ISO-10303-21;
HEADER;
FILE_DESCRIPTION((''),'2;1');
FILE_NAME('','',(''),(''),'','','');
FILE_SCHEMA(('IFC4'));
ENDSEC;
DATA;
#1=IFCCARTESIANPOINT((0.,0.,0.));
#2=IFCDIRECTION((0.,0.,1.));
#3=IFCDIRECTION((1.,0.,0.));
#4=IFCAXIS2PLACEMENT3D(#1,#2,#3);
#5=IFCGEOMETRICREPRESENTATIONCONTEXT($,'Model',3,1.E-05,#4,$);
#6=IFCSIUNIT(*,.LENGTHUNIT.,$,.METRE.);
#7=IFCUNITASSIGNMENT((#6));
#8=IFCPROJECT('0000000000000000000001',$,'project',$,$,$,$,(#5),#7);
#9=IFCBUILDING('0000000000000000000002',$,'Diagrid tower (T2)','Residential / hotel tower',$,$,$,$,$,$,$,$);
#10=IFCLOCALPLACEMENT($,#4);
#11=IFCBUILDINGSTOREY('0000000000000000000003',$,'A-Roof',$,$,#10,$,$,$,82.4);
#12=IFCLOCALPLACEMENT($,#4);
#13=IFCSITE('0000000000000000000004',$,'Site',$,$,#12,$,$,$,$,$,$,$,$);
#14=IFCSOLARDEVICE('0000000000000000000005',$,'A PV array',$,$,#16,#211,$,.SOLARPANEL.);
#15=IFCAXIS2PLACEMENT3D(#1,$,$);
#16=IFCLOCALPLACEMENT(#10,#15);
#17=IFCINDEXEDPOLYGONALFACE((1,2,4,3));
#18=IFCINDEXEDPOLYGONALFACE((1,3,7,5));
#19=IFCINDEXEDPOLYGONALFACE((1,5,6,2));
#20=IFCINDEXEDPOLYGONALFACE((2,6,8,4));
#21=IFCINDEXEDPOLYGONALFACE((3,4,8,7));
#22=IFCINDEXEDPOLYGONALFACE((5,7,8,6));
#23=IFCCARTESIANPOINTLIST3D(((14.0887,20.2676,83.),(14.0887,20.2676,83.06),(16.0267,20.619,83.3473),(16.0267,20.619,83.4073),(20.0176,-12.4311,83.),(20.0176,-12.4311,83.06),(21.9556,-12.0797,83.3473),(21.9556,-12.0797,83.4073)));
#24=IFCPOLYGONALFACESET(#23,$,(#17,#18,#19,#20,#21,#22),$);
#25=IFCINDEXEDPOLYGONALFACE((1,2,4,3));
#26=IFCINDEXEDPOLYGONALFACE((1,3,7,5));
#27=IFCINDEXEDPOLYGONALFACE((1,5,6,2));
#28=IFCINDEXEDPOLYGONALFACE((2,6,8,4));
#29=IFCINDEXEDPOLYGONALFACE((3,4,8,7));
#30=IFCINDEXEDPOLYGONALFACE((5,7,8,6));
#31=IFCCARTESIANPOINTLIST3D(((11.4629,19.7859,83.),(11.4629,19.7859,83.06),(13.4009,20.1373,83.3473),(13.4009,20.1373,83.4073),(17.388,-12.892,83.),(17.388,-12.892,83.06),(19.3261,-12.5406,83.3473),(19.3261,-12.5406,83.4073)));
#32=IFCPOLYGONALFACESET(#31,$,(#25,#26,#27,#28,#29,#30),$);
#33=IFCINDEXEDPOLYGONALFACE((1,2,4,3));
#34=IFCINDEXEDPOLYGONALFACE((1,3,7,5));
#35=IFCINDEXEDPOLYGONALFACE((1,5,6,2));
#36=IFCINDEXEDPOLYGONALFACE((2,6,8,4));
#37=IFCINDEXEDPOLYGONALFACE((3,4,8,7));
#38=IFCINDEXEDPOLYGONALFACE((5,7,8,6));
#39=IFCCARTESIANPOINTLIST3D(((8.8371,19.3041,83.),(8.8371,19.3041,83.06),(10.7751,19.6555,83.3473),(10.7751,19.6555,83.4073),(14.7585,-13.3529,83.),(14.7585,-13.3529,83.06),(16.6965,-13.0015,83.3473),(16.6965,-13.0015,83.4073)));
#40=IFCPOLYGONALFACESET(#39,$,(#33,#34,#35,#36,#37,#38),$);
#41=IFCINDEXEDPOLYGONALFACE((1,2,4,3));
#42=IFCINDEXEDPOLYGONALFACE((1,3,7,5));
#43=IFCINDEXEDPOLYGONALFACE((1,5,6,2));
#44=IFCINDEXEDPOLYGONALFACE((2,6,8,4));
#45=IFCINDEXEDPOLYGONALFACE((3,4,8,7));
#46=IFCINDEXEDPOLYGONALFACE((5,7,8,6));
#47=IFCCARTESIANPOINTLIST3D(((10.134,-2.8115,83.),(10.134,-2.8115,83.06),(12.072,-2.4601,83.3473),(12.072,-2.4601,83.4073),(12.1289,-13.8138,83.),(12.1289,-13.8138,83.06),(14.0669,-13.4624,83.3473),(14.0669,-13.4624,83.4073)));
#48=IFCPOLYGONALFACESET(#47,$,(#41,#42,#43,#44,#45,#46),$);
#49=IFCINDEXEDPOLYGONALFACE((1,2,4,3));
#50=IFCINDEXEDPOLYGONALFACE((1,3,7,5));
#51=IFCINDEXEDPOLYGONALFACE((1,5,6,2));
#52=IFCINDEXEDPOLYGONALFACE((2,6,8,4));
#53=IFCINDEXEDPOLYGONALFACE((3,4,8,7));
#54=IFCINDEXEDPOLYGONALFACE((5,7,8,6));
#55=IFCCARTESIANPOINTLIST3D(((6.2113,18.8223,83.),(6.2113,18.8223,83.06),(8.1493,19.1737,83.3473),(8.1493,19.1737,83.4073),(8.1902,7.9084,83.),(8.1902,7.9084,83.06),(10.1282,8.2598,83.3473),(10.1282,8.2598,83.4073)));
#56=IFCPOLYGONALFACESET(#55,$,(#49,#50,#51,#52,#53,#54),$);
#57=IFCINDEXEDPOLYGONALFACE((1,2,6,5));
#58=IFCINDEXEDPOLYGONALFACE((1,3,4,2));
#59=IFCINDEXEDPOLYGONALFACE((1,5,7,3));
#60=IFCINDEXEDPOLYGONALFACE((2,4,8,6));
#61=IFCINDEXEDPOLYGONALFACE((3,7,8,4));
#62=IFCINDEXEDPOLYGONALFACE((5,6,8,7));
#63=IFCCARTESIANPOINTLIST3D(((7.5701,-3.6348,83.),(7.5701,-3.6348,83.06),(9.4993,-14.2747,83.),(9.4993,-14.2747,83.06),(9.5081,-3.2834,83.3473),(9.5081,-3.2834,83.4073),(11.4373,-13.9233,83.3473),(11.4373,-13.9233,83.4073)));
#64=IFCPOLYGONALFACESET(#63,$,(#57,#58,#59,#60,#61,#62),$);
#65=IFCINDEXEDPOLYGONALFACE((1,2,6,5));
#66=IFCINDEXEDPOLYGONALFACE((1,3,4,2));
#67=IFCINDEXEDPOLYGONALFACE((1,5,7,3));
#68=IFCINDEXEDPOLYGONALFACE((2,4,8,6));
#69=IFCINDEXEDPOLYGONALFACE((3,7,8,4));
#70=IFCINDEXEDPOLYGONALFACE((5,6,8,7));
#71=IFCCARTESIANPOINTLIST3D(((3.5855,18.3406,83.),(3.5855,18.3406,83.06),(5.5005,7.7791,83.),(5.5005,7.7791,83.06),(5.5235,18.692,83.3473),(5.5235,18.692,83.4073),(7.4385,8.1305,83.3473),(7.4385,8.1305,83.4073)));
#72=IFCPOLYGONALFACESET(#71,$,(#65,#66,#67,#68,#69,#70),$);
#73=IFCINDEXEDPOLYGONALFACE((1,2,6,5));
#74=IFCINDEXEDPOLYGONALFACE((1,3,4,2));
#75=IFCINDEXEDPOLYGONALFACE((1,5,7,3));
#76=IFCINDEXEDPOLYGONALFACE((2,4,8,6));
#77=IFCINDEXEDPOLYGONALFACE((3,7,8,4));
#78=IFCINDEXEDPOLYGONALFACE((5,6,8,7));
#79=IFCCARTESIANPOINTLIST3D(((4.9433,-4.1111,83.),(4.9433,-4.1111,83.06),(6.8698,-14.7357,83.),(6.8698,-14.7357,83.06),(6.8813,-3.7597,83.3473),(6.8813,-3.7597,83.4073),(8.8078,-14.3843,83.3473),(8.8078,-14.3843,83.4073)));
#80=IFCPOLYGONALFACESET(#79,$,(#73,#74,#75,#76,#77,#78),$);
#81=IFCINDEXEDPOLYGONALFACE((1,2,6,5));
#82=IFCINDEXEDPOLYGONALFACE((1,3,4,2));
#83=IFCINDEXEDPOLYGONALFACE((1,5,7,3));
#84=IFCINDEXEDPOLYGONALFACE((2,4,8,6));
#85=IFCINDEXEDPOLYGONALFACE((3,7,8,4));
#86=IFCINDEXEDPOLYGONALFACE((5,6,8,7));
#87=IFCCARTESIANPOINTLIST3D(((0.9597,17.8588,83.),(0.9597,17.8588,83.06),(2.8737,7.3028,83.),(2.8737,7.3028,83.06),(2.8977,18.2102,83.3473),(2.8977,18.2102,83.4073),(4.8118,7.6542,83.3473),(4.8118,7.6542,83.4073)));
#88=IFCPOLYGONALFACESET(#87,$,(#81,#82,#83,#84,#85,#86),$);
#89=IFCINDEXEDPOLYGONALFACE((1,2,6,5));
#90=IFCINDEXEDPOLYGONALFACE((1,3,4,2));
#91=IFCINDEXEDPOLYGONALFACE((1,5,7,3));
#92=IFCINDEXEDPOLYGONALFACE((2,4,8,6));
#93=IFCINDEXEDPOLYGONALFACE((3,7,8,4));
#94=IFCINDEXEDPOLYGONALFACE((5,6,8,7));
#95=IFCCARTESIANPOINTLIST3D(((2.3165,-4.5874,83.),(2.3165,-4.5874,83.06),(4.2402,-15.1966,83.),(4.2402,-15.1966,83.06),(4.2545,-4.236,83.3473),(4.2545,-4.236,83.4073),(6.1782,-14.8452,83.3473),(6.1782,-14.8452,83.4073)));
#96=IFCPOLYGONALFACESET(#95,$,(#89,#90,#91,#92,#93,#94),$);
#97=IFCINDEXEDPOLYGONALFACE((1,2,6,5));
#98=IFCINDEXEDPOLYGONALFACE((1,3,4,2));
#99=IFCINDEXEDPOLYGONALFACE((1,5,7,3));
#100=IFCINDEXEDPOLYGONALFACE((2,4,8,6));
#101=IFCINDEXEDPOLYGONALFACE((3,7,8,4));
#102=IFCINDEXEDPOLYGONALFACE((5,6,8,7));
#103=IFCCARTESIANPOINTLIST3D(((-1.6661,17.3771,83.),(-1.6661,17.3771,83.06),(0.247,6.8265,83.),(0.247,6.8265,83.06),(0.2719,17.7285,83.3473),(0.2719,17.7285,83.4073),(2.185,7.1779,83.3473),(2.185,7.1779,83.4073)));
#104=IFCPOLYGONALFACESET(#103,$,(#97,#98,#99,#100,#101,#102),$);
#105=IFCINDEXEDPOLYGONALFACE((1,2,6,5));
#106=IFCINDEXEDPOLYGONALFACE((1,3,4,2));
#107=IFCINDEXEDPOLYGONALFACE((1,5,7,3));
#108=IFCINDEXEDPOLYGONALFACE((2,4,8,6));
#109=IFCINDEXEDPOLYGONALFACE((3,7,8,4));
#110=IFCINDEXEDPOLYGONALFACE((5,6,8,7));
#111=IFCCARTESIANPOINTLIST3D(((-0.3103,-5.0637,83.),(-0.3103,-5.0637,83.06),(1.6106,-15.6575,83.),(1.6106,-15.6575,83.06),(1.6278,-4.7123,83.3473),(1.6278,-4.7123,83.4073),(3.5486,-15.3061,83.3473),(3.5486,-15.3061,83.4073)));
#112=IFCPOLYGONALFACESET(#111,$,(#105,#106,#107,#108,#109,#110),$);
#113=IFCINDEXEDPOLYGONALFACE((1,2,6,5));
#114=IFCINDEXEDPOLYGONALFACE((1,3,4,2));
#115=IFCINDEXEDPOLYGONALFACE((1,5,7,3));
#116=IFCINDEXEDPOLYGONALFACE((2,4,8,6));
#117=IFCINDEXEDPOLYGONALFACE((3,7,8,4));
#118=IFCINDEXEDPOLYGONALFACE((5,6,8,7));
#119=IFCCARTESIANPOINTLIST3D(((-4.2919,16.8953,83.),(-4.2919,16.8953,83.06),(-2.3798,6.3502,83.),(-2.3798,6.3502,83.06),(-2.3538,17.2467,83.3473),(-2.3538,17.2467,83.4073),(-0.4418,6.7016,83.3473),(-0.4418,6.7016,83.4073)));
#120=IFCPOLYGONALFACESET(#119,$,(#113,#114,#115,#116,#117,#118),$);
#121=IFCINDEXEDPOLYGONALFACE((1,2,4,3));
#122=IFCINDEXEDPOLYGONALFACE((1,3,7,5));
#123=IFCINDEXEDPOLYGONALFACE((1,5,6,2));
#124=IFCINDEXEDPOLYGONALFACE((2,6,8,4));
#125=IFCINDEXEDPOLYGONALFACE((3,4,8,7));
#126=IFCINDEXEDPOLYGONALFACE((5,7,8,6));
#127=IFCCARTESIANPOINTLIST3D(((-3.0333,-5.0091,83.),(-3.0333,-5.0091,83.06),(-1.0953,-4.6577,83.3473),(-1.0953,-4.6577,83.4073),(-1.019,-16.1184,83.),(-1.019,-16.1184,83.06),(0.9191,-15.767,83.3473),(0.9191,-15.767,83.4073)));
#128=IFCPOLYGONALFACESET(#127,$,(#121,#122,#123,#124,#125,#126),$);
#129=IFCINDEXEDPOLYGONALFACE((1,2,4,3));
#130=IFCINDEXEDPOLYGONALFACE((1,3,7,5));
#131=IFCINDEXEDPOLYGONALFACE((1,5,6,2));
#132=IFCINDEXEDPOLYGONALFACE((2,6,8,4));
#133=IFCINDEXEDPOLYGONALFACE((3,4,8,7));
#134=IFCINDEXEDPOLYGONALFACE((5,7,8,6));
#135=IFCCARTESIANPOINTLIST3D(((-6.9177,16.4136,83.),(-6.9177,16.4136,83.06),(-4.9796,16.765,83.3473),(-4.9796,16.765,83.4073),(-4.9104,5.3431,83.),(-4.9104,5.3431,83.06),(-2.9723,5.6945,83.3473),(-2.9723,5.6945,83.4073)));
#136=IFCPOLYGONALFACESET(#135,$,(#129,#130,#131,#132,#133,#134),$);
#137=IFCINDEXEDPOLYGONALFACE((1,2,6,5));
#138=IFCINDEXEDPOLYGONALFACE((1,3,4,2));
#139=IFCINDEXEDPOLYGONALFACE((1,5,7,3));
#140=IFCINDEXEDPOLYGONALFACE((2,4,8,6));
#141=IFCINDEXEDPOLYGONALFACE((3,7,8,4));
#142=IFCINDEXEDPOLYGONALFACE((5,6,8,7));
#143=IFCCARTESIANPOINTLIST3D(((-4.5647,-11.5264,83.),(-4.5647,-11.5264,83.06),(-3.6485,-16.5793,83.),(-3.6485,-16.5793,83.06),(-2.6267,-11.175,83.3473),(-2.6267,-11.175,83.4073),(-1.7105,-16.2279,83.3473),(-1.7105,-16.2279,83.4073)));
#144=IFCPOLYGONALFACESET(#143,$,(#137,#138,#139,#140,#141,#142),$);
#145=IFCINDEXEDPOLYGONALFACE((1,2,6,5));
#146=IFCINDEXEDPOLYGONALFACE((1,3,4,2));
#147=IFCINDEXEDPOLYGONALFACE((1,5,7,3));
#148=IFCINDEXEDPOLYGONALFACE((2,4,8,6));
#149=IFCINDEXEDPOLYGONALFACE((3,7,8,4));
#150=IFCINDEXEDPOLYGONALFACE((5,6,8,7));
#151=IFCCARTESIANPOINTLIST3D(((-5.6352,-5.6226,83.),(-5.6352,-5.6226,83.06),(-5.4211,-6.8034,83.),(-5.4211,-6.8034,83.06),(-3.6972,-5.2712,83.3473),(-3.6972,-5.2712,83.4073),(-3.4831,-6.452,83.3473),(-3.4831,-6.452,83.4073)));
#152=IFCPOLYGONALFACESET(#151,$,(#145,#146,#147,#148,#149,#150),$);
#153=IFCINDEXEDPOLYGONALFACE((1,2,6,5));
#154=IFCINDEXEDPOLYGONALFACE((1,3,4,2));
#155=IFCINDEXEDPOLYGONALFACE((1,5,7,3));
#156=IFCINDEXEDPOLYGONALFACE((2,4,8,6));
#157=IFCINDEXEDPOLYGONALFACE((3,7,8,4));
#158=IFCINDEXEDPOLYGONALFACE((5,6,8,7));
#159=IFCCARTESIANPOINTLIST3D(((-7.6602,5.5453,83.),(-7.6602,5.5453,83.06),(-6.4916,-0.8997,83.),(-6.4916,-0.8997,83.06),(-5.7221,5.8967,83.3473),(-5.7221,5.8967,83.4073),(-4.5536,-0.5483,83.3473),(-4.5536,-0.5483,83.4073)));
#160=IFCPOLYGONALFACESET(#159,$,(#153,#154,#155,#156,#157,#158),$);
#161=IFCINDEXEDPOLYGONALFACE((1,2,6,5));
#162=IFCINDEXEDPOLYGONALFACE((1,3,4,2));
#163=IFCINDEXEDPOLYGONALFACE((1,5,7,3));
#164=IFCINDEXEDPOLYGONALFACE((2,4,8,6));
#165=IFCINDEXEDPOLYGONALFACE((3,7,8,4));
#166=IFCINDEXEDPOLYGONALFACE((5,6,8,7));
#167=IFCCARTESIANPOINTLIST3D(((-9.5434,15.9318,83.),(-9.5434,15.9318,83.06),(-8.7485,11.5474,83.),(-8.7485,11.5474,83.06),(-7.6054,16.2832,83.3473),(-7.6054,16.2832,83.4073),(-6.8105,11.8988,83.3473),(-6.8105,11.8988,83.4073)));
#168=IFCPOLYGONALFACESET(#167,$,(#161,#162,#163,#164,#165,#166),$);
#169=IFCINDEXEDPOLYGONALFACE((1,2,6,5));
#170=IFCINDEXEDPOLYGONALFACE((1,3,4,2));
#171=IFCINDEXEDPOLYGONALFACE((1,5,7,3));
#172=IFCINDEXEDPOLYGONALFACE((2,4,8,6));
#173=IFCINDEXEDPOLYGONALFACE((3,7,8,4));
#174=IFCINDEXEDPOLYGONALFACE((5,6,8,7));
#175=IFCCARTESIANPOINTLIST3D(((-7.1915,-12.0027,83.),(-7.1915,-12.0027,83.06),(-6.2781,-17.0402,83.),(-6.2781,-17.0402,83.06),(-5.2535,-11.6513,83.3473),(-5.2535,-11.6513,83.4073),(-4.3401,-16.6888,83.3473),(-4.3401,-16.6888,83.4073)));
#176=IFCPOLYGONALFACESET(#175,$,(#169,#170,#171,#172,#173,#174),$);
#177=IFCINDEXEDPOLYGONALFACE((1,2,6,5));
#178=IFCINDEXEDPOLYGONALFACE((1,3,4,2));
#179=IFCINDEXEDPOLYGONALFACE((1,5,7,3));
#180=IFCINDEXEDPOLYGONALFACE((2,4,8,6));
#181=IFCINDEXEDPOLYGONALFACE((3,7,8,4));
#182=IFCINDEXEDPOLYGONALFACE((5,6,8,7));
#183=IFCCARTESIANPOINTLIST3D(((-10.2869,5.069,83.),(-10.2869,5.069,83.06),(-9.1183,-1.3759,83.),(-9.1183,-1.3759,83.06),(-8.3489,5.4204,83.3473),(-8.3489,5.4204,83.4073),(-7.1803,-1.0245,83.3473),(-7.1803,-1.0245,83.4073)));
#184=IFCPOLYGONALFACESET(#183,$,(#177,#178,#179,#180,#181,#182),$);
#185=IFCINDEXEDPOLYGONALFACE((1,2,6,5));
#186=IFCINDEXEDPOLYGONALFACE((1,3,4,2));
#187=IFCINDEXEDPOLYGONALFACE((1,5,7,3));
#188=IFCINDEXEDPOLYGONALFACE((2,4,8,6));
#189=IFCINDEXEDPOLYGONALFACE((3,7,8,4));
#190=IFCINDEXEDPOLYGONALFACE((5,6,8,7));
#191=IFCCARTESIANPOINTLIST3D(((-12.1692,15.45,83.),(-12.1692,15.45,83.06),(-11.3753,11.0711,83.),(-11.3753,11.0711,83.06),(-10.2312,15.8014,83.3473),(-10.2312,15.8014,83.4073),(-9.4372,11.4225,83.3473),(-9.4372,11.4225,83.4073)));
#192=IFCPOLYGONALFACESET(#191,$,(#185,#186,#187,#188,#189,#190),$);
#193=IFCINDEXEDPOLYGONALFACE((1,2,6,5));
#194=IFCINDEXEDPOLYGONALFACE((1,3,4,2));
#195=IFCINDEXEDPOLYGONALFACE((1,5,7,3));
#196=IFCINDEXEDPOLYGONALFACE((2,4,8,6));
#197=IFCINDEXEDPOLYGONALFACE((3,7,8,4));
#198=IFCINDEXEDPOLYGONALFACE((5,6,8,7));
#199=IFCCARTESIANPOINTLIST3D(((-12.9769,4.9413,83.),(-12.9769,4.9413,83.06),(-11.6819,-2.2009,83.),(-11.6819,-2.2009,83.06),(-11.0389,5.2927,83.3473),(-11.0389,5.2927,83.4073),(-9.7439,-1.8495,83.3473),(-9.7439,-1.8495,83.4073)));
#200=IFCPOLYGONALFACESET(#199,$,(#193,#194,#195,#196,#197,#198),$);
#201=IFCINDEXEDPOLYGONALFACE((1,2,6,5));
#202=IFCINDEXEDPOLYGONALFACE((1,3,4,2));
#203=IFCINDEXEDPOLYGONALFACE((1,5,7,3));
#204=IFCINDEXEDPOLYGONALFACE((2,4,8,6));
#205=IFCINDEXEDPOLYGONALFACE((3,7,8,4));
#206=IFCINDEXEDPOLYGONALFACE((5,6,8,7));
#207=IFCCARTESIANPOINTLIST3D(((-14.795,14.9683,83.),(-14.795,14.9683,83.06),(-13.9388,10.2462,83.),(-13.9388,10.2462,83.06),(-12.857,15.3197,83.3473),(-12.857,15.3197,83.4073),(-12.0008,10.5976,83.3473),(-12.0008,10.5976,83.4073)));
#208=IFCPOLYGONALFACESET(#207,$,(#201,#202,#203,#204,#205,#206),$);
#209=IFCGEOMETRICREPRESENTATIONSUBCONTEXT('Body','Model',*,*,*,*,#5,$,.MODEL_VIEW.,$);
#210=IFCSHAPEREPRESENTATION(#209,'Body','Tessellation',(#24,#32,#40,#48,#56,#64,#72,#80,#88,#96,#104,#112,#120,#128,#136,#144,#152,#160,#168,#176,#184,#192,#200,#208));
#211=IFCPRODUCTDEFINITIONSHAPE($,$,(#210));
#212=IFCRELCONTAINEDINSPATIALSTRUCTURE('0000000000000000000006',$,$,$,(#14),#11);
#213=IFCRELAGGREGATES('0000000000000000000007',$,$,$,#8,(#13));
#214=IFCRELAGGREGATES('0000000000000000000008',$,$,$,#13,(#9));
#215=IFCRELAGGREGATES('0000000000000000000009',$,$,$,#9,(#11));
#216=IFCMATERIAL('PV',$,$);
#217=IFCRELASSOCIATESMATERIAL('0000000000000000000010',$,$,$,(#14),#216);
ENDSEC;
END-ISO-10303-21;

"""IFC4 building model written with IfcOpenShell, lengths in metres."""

from ifc_helpers import new_model, si_unit, frame, origin_with_axes, place, context, subcontext, project, spatial, polyline, outline, extrude, material, element, save


model = new_model("IFC4")

# Units and contexts
model_context = context("Model", 3, precision=1e-05, world=origin_with_axes())
body_context = subcontext(model_context, "Body", "Model", "MODEL_VIEW")
ifc_project = project(units=[si_unit("LENGTHUNIT", "METRE")], contexts=[model_context])

# Site, building, storey
site_placement = place(None, origin_with_axes())
site = spatial("IfcSite", under=ifc_project, at=site_placement, Name="Site")
building = spatial("IfcBuilding", under=site, Name="Diagrid tower (T2)", Description="Residential / hotel tower")
storey_placement = place(None, origin_with_axes())
storey = spatial("IfcBuildingStorey", under=building, at=storey_placement, Name="A-Roof", Elevation=82.4)

# Solar device
ifc_material_1 = material(Name="PV")
solar_device_placement = place(storey_placement, origin_with_axes())
element("IfcSolarDevice", 1, at=solar_device_placement, inside=storey, material=ifc_material_1, Name="A PV array", PredefinedType="SOLARPANEL", context=body_context, shape_type="SweptSolid", body=[
    extrude(outline(polyline([(0.0, 0.6473), (1.9696, 0.3), (1.9696, 0.36), (0.0, 0.7073), (0.0, 0.6473)])), frame((21.9556, -12.0797, 82.7), z_axis=(-0.178411, 0.983956, 0.0), x_axis=(-0.983956, -0.178411, 0.0)), (0.0, 0.0, 1.0), 33.2319),
    extrude(outline(polyline([(0.0, 0.6473), (1.9696, 0.3), (1.9696, 0.36), (0.0, 0.7073), (0.0, 0.6473)])), frame((19.3261, -12.5406, 82.7), z_axis=(-0.178411, 0.983956, 0.0), x_axis=(-0.983956, -0.178411, 0.0)), (0.0, 0.0, 1.0), 33.2107),
    extrude(outline(polyline([(0.0, 0.6473), (1.9696, 0.3), (1.9696, 0.36), (0.0, 0.7073), (0.0, 0.6473)])), frame((16.6965, -13.0015, 82.7), z_axis=(-0.178411, 0.983956, 0.0), x_axis=(-0.983956, -0.178411, 0.0)), (0.0, 0.0, 1.0), 33.1895),
    extrude(outline(polyline([(0.0, 0.6473), (1.9696, 0.3), (1.9696, 0.36), (0.0, 0.7073), (0.0, 0.6473)])), frame((14.0669, -13.4624, 82.7), z_axis=(-0.178411, 0.983956, 0.0), x_axis=(-0.983956, -0.178411, 0.0)), (0.0, 0.0, 1.0), 11.1817),
    extrude(outline(polyline([(0.0, 0.6473), (1.9696, 0.3), (1.9696, 0.36), (0.0, 0.7073), (0.0, 0.6473)])), frame((10.1282, 8.2598, 82.7), z_axis=(-0.178411, 0.983956, 0.0), x_axis=(-0.983956, -0.178411, 0.0)), (0.0, 0.0, 1.0), 11.0919),
    extrude(outline(polyline([(0.0, 0.6473), (1.9696, 0.3), (1.9696, 0.36), (0.0, 0.7073), (0.0, 0.6473)])), frame((11.4373, -13.9233, 82.7), z_axis=(-0.178411, 0.983956, 0.0), x_axis=(-0.983956, -0.178411, 0.0)), (0.0, 0.0, 1.0), 10.8135),
    extrude(outline(polyline([(0.0, 0.6473), (1.9696, 0.3), (1.9696, 0.36), (0.0, 0.7073), (0.0, 0.6473)])), frame((7.4385, 8.1305, 82.7), z_axis=(-0.178411, 0.983956, 0.0), x_axis=(-0.983956, -0.178411, 0.0)), (0.0, 0.0, 1.0), 10.7337),
    extrude(outline(polyline([(0.0, 0.6473), (1.9696, 0.3), (1.9696, 0.36), (0.0, 0.7073), (0.0, 0.6473)])), frame((8.8078, -14.3843, 82.7), z_axis=(-0.178411, 0.983956, 0.0), x_axis=(-0.983956, -0.178411, 0.0)), (0.0, 0.0, 1.0), 10.7978),
    extrude(outline(polyline([(0.0, 0.6473), (1.9696, 0.3), (1.9696, 0.36), (0.0, 0.7073), (0.0, 0.6473)])), frame((4.8118, 7.6542, 82.7), z_axis=(-0.178411, 0.983956, 0.0), x_axis=(-0.983956, -0.178411, 0.0)), (0.0, 0.0, 1.0), 10.7281),
    extrude(outline(polyline([(0.0, 0.6473), (1.9696, 0.3), (1.9696, 0.36), (0.0, 0.7073), (0.0, 0.6473)])), frame((6.1782, -14.8452, 82.7), z_axis=(-0.178411, 0.983956, 0.0), x_axis=(-0.983956, -0.178411, 0.0)), (0.0, 0.0, 1.0), 10.7822),
    extrude(outline(polyline([(0.0, 0.6473), (1.9696, 0.3), (1.9696, 0.36), (0.0, 0.7073), (0.0, 0.6473)])), frame((2.185, 7.1779, 82.7), z_axis=(-0.178411, 0.983956, 0.0), x_axis=(-0.983956, -0.178411, 0.0)), (0.0, 0.0, 1.0), 10.7226),
    extrude(outline(polyline([(0.0, 0.6473), (1.9696, 0.3), (1.9696, 0.36), (0.0, 0.7073), (0.0, 0.6473)])), frame((3.5486, -15.3061, 82.7), z_axis=(-0.178411, 0.983956, 0.0), x_axis=(-0.983956, -0.178411, 0.0)), (0.0, 0.0, 1.0), 10.7666),
    extrude(outline(polyline([(0.0, 0.6473), (1.9696, 0.3), (1.9696, 0.36), (0.0, 0.7073), (0.0, 0.6473)])), frame((-0.4418, 6.7016, 82.7), z_axis=(-0.178411, 0.983956, 0.0), x_axis=(-0.983956, -0.178411, 0.0)), (0.0, 0.0, 1.0), 10.717),
    extrude(outline(polyline([(0.0, 0.6473), (1.9696, 0.3), (1.9696, 0.36), (0.0, 0.7073), (0.0, 0.6473)])), frame((0.9191, -15.767, 82.7), z_axis=(-0.178411, 0.983956, 0.0), x_axis=(-0.983956, -0.178411, 0.0)), (0.0, 0.0, 1.0), 11.2904),
    extrude(outline(polyline([(0.0, 0.6473), (1.9696, 0.3), (1.9696, 0.36), (0.0, 0.7073), (0.0, 0.6473)])), frame((-2.9723, 5.6945, 82.7), z_axis=(-0.178411, 0.983956, 0.0), x_axis=(-0.983956, -0.178411, 0.0)), (0.0, 0.0, 1.0), 11.2509),
    extrude(outline(polyline([(0.0, 0.6473), (1.9696, 0.3), (1.9696, 0.36), (0.0, 0.7073), (0.0, 0.6473)])), frame((-1.7105, -16.2279, 82.7), z_axis=(-0.178411, 0.983956, 0.0), x_axis=(-0.983956, -0.178411, 0.0)), (0.0, 0.0, 1.0), 5.1353),
    extrude(outline(polyline([(0.0, 0.6473), (1.9696, 0.3), (1.9696, 0.36), (0.0, 0.7073), (0.0, 0.6473)])), frame((-3.4831, -6.452, 82.7), z_axis=(-0.178411, 0.983956, 0.0), x_axis=(-0.983956, -0.178411, 0.0)), (0.0, 0.0, 1.0), 1.2),
    extrude(outline(polyline([(0.0, 0.6473), (1.9696, 0.3), (1.9696, 0.36), (0.0, 0.7073), (0.0, 0.6473)])), frame((-4.5536, -0.5483, 82.7), z_axis=(-0.178411, 0.983956, 0.0), x_axis=(-0.983956, -0.178411, 0.0)), (0.0, 0.0, 1.0), 6.55),
    extrude(outline(polyline([(0.0, 0.6473), (1.9696, 0.3), (1.9696, 0.36), (0.0, 0.7073), (0.0, 0.6473)])), frame((-6.8105, 11.8988, 82.7), z_axis=(-0.178411, 0.983956, 0.0), x_axis=(-0.983956, -0.178411, 0.0)), (0.0, 0.0, 1.0), 4.4559),
    extrude(outline(polyline([(0.0, 0.6473), (1.9696, 0.3), (1.9696, 0.36), (0.0, 0.7073), (0.0, 0.6473)])), frame((-4.3401, -16.6888, 82.7), z_axis=(-0.178411, 0.983956, 0.0), x_axis=(-0.983956, -0.178411, 0.0)), (0.0, 0.0, 1.0), 5.1197),
    extrude(outline(polyline([(0.0, 0.6473), (1.9696, 0.3), (1.9696, 0.36), (0.0, 0.7073), (0.0, 0.6473)])), frame((-7.1803, -1.0245, 82.7), z_axis=(-0.178411, 0.983956, 0.0), x_axis=(-0.983956, -0.178411, 0.0)), (0.0, 0.0, 1.0), 6.55),
    extrude(outline(polyline([(0.0, 0.6473), (1.9696, 0.3), (1.9696, 0.36), (0.0, 0.7073), (0.0, 0.6473)])), frame((-9.4372, 11.4225, 82.7), z_axis=(-0.178411, 0.983956, 0.0), x_axis=(-0.983956, -0.178411, 0.0)), (0.0, 0.0, 1.0), 4.4503),
    extrude(outline(polyline([(0.0, 0.6473), (1.9696, 0.3), (1.9696, 0.36), (0.0, 0.7073), (0.0, 0.6473)])), frame((-9.7439, -1.8495, 82.7), z_axis=(-0.178411, 0.983956, 0.0), x_axis=(-0.983956, -0.178411, 0.0)), (0.0, 0.0, 1.0), 7.2587),
    extrude(outline(polyline([(0.0, 0.6473), (1.9696, 0.3), (1.9696, 0.36), (0.0, 0.7073), (0.0, 0.6473)])), frame((-12.0008, 10.5976, 82.7), z_axis=(-0.178411, 0.983956, 0.0), x_axis=(-0.983956, -0.178411, 0.0)), (0.0, 0.0, 1.0), 4.7991),
])

save(model, "model.ifc")
